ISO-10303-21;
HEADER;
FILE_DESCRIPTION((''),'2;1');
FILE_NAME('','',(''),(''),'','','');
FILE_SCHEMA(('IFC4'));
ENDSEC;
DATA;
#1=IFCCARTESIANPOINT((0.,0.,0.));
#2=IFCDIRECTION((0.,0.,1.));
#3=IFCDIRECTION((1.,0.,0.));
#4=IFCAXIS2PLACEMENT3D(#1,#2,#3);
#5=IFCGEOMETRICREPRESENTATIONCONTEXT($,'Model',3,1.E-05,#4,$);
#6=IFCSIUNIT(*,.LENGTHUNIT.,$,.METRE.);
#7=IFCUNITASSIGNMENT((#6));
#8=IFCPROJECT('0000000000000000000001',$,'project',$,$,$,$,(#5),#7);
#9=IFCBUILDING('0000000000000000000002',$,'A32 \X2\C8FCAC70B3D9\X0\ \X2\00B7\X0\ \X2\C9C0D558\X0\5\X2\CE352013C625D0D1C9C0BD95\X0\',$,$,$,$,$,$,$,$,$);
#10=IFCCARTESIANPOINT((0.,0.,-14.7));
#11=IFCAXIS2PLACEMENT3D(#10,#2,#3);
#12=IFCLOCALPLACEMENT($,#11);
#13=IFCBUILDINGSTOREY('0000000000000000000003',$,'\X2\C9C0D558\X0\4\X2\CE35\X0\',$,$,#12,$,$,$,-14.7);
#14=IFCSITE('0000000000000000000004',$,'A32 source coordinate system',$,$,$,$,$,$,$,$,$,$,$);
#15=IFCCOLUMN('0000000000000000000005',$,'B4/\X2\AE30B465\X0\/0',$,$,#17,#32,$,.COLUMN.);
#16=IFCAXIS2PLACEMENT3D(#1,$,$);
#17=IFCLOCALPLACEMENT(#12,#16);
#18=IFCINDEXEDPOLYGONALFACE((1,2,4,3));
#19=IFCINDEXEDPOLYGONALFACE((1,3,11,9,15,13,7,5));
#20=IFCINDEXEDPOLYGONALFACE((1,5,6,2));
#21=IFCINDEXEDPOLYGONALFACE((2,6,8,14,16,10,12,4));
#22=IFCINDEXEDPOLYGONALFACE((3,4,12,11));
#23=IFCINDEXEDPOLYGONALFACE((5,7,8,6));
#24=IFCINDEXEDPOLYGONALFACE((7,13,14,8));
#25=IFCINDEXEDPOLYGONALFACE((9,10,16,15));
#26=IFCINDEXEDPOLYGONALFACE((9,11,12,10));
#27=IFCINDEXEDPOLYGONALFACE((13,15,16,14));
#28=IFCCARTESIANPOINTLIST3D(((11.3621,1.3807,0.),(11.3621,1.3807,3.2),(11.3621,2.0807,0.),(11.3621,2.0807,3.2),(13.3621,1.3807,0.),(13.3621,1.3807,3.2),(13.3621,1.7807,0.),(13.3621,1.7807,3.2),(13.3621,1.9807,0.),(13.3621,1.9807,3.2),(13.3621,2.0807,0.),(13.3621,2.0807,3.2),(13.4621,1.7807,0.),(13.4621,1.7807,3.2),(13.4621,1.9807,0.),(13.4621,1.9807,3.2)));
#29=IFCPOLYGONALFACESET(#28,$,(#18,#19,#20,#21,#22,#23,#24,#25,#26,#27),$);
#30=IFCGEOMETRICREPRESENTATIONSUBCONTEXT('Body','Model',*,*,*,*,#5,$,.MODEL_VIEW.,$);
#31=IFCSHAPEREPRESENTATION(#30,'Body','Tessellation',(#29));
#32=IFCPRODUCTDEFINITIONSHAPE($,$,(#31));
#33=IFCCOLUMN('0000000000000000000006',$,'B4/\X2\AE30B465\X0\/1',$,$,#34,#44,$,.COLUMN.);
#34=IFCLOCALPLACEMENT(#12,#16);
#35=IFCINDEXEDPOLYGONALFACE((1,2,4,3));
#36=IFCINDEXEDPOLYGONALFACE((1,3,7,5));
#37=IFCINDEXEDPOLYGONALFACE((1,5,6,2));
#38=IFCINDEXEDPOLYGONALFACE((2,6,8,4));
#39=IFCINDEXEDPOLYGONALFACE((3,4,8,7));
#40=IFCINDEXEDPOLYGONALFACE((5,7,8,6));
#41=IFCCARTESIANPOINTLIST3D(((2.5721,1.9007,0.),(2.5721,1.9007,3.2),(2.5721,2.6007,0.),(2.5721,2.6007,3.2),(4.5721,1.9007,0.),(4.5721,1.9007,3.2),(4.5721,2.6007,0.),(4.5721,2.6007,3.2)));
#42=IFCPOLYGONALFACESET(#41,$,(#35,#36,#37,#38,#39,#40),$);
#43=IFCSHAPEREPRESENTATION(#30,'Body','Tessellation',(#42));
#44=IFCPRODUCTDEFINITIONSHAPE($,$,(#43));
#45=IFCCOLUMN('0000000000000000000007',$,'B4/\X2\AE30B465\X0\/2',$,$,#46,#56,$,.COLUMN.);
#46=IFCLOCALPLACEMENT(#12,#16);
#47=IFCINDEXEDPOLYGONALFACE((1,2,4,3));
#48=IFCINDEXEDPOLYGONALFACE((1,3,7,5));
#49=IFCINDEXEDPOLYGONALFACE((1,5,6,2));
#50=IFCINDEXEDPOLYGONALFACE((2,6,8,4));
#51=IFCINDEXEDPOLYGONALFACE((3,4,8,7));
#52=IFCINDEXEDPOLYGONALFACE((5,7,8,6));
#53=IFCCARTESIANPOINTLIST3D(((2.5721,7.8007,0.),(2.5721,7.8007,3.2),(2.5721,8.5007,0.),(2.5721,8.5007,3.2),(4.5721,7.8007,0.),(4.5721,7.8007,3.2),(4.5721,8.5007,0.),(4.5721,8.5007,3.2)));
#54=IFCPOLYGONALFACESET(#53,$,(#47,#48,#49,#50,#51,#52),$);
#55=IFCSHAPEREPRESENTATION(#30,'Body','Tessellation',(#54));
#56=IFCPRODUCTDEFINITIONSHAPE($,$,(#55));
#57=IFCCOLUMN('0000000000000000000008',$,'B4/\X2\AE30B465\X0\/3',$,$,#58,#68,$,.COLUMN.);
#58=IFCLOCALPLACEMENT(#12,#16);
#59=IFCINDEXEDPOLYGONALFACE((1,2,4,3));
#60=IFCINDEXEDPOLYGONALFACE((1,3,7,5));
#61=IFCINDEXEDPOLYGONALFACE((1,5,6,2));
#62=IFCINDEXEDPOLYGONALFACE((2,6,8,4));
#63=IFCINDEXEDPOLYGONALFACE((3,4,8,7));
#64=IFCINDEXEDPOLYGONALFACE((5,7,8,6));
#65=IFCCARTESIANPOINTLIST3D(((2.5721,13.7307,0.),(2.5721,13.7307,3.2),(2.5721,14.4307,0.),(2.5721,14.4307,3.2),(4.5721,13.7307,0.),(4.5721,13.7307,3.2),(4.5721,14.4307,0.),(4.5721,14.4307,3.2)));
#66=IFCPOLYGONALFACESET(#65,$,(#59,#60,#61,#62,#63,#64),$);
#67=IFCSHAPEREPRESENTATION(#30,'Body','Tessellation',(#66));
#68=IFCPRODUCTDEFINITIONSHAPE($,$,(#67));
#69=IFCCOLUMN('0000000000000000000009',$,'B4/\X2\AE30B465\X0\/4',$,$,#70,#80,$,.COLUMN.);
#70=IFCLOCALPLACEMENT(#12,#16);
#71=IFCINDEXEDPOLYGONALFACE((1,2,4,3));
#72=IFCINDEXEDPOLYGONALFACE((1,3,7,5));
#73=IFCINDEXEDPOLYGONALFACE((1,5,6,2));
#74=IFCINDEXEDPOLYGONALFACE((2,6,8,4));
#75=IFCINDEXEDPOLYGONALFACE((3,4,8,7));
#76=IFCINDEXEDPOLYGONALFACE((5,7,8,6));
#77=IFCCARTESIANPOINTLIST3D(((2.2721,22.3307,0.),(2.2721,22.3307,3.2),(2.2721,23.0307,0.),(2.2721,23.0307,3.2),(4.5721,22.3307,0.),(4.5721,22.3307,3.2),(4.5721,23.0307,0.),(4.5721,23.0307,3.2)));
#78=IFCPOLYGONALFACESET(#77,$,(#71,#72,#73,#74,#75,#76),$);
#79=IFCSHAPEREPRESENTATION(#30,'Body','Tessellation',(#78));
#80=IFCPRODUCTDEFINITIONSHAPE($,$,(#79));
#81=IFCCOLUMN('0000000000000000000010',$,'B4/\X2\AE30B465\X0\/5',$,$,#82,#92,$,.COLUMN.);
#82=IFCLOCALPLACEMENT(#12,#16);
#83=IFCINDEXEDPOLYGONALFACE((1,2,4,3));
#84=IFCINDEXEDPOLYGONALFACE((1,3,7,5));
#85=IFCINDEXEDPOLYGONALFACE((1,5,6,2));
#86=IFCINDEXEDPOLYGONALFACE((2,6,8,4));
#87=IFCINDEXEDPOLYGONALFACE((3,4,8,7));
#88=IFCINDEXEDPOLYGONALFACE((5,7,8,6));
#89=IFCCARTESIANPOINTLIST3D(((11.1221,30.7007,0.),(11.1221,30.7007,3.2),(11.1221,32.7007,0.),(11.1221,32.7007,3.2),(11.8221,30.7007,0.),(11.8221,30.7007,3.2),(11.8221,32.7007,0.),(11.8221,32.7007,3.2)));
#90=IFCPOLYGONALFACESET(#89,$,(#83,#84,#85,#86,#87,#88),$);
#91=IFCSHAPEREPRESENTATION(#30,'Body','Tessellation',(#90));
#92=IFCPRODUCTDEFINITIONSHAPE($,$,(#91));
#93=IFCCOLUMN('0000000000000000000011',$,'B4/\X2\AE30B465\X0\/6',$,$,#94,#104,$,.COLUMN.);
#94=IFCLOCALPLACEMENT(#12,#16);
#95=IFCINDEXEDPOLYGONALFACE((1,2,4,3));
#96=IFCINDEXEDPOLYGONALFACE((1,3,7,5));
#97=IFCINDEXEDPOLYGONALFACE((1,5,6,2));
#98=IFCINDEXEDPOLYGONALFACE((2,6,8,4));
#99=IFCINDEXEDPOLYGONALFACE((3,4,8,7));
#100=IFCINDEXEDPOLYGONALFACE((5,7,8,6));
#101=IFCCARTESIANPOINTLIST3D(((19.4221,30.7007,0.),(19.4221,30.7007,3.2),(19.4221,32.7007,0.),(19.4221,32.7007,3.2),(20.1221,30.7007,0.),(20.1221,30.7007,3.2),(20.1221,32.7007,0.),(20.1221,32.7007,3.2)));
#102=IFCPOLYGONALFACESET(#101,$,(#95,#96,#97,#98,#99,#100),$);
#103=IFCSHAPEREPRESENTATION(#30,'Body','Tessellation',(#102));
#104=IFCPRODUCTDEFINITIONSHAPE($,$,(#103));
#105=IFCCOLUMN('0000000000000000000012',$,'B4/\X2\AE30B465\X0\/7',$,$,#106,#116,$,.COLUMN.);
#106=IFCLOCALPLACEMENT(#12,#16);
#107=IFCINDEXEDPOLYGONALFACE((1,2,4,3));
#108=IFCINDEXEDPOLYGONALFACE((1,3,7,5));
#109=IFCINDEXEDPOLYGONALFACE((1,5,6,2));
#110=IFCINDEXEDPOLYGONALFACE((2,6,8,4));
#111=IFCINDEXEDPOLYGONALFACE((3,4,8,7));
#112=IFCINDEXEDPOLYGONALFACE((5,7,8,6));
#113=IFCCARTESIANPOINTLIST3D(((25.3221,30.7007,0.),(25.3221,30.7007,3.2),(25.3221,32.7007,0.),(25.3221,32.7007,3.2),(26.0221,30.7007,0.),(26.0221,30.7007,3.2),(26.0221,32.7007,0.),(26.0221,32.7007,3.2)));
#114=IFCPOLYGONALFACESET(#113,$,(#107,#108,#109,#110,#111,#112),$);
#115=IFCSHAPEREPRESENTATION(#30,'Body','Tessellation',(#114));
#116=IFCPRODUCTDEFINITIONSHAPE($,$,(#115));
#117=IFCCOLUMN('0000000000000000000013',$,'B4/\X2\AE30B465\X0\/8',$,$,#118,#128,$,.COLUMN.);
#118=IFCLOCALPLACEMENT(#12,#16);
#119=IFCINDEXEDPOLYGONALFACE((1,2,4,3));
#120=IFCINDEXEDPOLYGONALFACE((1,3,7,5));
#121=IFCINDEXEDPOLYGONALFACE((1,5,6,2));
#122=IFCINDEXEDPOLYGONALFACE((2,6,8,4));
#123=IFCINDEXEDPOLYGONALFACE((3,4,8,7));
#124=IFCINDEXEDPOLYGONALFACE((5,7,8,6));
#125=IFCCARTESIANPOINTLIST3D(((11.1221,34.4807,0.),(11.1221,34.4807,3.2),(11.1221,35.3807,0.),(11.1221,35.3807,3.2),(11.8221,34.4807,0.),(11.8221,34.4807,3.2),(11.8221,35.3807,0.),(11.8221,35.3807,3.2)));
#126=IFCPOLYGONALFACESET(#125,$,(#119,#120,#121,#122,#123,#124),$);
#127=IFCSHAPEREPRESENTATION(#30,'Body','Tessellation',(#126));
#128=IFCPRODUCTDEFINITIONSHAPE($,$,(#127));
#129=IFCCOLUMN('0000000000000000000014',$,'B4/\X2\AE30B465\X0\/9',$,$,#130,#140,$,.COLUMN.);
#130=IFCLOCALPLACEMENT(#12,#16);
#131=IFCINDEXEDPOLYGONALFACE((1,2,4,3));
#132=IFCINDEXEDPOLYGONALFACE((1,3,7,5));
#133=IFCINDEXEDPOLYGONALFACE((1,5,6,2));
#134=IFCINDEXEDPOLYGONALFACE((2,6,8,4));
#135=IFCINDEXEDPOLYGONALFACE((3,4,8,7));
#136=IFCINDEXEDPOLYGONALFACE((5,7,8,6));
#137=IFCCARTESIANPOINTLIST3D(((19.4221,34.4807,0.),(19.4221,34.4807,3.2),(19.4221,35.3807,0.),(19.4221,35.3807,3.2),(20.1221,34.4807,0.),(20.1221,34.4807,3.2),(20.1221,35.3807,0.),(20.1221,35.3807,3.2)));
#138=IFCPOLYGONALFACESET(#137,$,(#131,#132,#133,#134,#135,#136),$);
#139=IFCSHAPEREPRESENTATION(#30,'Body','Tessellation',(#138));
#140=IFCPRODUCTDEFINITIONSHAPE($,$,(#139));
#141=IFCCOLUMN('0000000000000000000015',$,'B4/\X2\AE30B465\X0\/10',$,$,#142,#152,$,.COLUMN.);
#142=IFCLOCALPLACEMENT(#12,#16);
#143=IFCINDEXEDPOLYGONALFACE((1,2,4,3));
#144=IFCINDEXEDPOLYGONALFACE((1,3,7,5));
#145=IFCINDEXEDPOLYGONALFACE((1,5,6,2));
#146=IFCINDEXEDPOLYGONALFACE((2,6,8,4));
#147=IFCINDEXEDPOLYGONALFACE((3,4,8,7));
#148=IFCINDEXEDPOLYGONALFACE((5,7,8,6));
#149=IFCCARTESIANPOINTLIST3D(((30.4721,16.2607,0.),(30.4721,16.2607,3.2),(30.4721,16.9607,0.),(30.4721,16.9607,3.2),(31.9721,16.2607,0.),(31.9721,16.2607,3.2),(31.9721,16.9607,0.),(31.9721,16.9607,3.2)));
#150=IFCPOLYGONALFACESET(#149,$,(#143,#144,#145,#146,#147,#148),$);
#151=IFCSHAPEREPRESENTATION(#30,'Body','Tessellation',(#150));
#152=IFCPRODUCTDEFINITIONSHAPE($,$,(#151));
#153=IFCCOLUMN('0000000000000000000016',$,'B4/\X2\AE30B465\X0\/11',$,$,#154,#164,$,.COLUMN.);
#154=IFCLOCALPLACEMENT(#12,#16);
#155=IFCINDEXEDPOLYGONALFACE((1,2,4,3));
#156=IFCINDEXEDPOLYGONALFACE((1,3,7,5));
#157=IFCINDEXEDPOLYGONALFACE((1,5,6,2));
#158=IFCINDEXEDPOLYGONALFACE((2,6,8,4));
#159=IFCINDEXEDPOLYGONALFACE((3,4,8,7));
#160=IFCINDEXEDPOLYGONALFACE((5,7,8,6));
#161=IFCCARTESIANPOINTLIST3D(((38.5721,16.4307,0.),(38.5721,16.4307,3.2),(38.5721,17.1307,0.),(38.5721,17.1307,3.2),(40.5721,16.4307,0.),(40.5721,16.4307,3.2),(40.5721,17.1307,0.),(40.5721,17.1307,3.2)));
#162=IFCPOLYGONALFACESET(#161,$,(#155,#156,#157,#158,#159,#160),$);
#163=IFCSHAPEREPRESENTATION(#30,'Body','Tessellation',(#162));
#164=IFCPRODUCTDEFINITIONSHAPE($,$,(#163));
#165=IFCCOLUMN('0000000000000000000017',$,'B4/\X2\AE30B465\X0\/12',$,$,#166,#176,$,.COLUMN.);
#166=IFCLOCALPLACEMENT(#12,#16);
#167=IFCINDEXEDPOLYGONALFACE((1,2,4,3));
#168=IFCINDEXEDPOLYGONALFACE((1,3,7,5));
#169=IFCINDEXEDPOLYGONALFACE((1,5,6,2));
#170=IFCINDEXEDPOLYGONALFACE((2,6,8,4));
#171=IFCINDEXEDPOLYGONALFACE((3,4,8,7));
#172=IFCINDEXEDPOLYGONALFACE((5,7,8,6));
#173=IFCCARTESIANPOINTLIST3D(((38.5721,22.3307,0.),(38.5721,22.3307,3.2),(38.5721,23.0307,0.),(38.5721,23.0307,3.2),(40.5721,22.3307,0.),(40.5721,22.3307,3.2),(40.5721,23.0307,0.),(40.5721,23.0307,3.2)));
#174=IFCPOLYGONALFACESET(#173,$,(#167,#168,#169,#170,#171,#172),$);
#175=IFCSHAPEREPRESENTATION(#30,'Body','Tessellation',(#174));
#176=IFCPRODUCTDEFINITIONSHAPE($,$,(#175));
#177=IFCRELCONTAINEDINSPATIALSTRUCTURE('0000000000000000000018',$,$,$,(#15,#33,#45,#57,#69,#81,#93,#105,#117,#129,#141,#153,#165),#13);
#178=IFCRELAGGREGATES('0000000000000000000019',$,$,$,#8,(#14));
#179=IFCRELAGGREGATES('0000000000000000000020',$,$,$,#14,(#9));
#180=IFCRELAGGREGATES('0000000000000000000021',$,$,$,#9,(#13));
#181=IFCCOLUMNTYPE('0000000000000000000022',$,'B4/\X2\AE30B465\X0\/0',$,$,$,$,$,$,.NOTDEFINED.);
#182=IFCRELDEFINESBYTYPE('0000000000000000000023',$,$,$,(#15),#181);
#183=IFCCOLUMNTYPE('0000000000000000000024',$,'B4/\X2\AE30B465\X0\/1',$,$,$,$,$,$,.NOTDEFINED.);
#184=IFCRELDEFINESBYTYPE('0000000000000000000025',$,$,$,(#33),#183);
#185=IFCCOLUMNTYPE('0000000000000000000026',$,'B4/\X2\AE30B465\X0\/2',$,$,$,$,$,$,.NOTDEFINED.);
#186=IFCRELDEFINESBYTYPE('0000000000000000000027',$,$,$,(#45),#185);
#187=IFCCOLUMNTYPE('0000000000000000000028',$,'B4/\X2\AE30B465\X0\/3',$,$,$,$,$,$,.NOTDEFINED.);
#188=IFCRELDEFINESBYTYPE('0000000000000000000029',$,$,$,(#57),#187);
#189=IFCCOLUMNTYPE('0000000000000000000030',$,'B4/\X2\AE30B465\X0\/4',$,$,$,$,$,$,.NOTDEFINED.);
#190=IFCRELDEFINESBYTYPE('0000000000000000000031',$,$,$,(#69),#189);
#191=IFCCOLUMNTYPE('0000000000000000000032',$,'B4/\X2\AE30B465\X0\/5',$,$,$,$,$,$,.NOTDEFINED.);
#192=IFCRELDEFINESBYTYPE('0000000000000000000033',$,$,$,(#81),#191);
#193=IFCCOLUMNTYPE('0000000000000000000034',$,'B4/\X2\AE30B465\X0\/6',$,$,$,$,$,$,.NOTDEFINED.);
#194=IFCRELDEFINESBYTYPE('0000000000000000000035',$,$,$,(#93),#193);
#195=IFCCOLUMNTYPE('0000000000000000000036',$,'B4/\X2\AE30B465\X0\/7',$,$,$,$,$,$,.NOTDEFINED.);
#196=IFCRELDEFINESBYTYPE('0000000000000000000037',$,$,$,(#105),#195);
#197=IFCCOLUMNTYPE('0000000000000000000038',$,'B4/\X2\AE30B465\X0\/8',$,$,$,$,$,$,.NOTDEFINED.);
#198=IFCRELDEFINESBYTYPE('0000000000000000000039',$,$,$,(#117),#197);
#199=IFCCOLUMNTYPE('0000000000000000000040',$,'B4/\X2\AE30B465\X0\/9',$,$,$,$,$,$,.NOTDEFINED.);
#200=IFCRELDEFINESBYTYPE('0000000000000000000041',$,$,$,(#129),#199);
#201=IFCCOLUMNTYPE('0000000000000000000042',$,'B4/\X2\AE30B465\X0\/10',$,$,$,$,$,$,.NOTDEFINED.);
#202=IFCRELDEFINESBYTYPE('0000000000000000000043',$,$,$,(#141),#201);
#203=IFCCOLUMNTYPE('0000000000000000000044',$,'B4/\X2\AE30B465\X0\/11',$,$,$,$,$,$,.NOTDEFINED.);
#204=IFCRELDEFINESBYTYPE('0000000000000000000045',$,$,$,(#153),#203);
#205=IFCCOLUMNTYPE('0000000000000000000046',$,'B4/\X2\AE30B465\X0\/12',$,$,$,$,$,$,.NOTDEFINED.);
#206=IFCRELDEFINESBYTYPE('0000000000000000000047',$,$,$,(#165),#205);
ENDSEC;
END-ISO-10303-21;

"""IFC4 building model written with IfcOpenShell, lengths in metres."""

from ifc_helpers import new_model, si_unit, frame, origin, origin_with_axes, place, context, subcontext, project, spatial, polyline, outline, extrude, source, transform, mapped, type_object, type_shapes, element, save


model = new_model("IFC4")

# Units and contexts
model_context = context("Model", 3, precision=1e-05, world=origin_with_axes())
body_context = subcontext(model_context, "Body", "Model", "MODEL_VIEW")
ifc_project = project(units=[si_unit("LENGTHUNIT", "METRE")], contexts=[model_context])

# Site, building, storey
site = spatial("IfcSite", under=ifc_project, Name="A32 source coordinate system")
building = spatial("IfcBuilding", under=site, Name="A32 주거동 · 지하5층–옥탑지붕")
storey_placement = place(None, frame((0.0, 0.0, -14.7), z_axis=(0.0, 0.0, 1.0), x_axis=(1.0, 0.0, 0.0)))
storey = spatial("IfcBuildingStorey", under=building, at=storey_placement, Name="지하4층", Elevation=-14.7)

# Columns
column_type_1 = type_object("IfcColumnType", Name="B4/기둥/0", PredefinedType="NOTDEFINED")
shared_shape_1 = source(origin(), body_context, "Body", "SweptSolid", [
    extrude(outline(polyline([(11.3621, 1.3807), (11.3621, 2.0807), (13.3621, 2.0807), (13.3621, 1.9807), (13.4621, 1.9807), (13.4621, 1.7807), (13.3621, 1.7807), (13.3621, 1.3807), (11.3621, 1.3807)])), origin(), (0.0, 0.0, 1.0), 3.2),
])
type_shapes(column_type_1, [shared_shape_1])
column_1_placement = place(storey_placement, origin_with_axes())
element("IfcColumn", 1, at=column_1_placement, inside=storey, type_object=column_type_1, Name="B4/기둥/0", PredefinedType="COLUMN", context=body_context, shape_type="MappedRepresentation", body=[
    mapped(shared_shape_1, transform((0.0, 0.0, 0.0), scale=1.0)),
])
column_type_2 = type_object("IfcColumnType", Name="B4/기둥/1", PredefinedType="NOTDEFINED")
shared_shape_2 = source(origin(), body_context, "Body", "SweptSolid", [
    extrude(outline(polyline([(4.5721, 1.9007), (2.5721, 1.9007), (2.5721, 2.6007), (4.5721, 2.6007), (4.5721, 1.9007)])), origin(), (0.0, 0.0, 1.0), 3.2),
])
type_shapes(column_type_2, [shared_shape_2])
column_2_placement = place(storey_placement, origin_with_axes())
element("IfcColumn", 2, at=column_2_placement, inside=storey, type_object=column_type_2, Name="B4/기둥/1", PredefinedType="COLUMN", context=body_context, shape_type="MappedRepresentation", body=[
    mapped(shared_shape_2, transform((0.0, 0.0, 0.0), scale=1.0)),
])
column_type_3 = type_object("IfcColumnType", Name="B4/기둥/2", PredefinedType="NOTDEFINED")
shared_shape_3 = source(origin(), body_context, "Body", "SweptSolid", [
    extrude(outline(polyline([(4.5721, 7.8007), (2.5721, 7.8007), (2.5721, 8.5007), (4.5721, 8.5007), (4.5721, 7.8007)])), origin(), (0.0, 0.0, 1.0), 3.2),
])
type_shapes(column_type_3, [shared_shape_3])
column_3_placement = place(storey_placement, origin_with_axes())
element("IfcColumn", 3, at=column_3_placement, inside=storey, type_object=column_type_3, Name="B4/기둥/2", PredefinedType="COLUMN", context=body_context, shape_type="MappedRepresentation", body=[
    mapped(shared_shape_3, transform((0.0, 0.0, 0.0), scale=1.0)),
])
column_type_4 = type_object("IfcColumnType", Name="B4/기둥/3", PredefinedType="NOTDEFINED")
shared_shape_4 = source(origin(), body_context, "Body", "SweptSolid", [
    extrude(outline(polyline([(4.5721, 14.4307), (4.5721, 13.7307), (2.5721, 13.7307), (2.5721, 14.4307), (4.5721, 14.4307)])), origin(), (0.0, 0.0, 1.0), 3.2),
])
type_shapes(column_type_4, [shared_shape_4])
column_4_placement = place(storey_placement, origin_with_axes())
element("IfcColumn", 4, at=column_4_placement, inside=storey, type_object=column_type_4, Name="B4/기둥/3", PredefinedType="COLUMN", context=body_context, shape_type="MappedRepresentation", body=[
    mapped(shared_shape_4, transform((0.0, 0.0, 0.0), scale=1.0)),
])
column_type_5 = type_object("IfcColumnType", Name="B4/기둥/4", PredefinedType="NOTDEFINED")
shared_shape_5 = source(origin(), body_context, "Body", "SweptSolid", [
    extrude(outline(polyline([(2.2721, 23.0307), (4.5721, 23.0307), (4.5721, 22.3307), (2.2721, 22.3307), (2.2721, 23.0307)])), origin(), (0.0, 0.0, 1.0), 3.2),
])
type_shapes(column_type_5, [shared_shape_5])
column_5_placement = place(storey_placement, origin_with_axes())
element("IfcColumn", 5, at=column_5_placement, inside=storey, type_object=column_type_5, Name="B4/기둥/4", PredefinedType="COLUMN", context=body_context, shape_type="MappedRepresentation", body=[
    mapped(shared_shape_5, transform((0.0, 0.0, 0.0), scale=1.0)),
])
column_type_6 = type_object("IfcColumnType", Name="B4/기둥/5", PredefinedType="NOTDEFINED")
shared_shape_6 = source(origin(), body_context, "Body", "SweptSolid", [
    extrude(outline(polyline([(11.8221, 30.7007), (11.1221, 30.7007), (11.1221, 32.7007), (11.8221, 32.7007), (11.8221, 30.7007)])), origin(), (0.0, 0.0, 1.0), 3.2),
])
type_shapes(column_type_6, [shared_shape_6])
column_6_placement = place(storey_placement, origin_with_axes())
element("IfcColumn", 6, at=column_6_placement, inside=storey, type_object=column_type_6, Name="B4/기둥/5", PredefinedType="COLUMN", context=body_context, shape_type="MappedRepresentation", body=[
    mapped(shared_shape_6, transform((0.0, 0.0, 0.0), scale=1.0)),
])
column_type_7 = type_object("IfcColumnType", Name="B4/기둥/6", PredefinedType="NOTDEFINED")
shared_shape_7 = source(origin(), body_context, "Body", "SweptSolid", [
    extrude(outline(polyline([(20.1221, 30.7007), (19.4221, 30.7007), (19.4221, 32.7007), (20.1221, 32.7007), (20.1221, 30.7007)])), origin(), (0.0, 0.0, 1.0), 3.2),
])
type_shapes(column_type_7, [shared_shape_7])
column_7_placement = place(storey_placement, origin_with_axes())
element("IfcColumn", 7, at=column_7_placement, inside=storey, type_object=column_type_7, Name="B4/기둥/6", PredefinedType="COLUMN", context=body_context, shape_type="MappedRepresentation", body=[
    mapped(shared_shape_7, transform((0.0, 0.0, 0.0), scale=1.0)),
])
column_type_8 = type_object("IfcColumnType", Name="B4/기둥/7", PredefinedType="NOTDEFINED")
shared_shape_8 = source(origin(), body_context, "Body", "SweptSolid", [
    extrude(outline(polyline([(26.0221, 30.7007), (25.3221, 30.7007), (25.3221, 32.7007), (26.0221, 32.7007), (26.0221, 30.7007)])), origin(), (0.0, 0.0, 1.0), 3.2),
])
type_shapes(column_type_8, [shared_shape_8])
column_8_placement = place(storey_placement, origin_with_axes())
element("IfcColumn", 8, at=column_8_placement, inside=storey, type_object=column_type_8, Name="B4/기둥/7", PredefinedType="COLUMN", context=body_context, shape_type="MappedRepresentation", body=[
    mapped(shared_shape_8, transform((0.0, 0.0, 0.0), scale=1.0)),
])
column_type_9 = type_object("IfcColumnType", Name="B4/기둥/8", PredefinedType="NOTDEFINED")
shared_shape_9 = source(origin(), body_context, "Body", "SweptSolid", [
    extrude(outline(polyline([(11.1221, 34.4807), (11.1221, 35.3807), (11.8221, 35.3807), (11.8221, 34.4807), (11.1221, 34.4807)])), origin(), (0.0, 0.0, 1.0), 3.2),
])
type_shapes(column_type_9, [shared_shape_9])
column_9_placement = place(storey_placement, origin_with_axes())
element("IfcColumn", 9, at=column_9_placement, inside=storey, type_object=column_type_9, Name="B4/기둥/8", PredefinedType="COLUMN", context=body_context, shape_type="MappedRepresentation", body=[
    mapped(shared_shape_9, transform((0.0, 0.0, 0.0), scale=1.0)),
])
column_type_10 = type_object("IfcColumnType", Name="B4/기둥/9", PredefinedType="NOTDEFINED")
shared_shape_10 = source(origin(), body_context, "Body", "SweptSolid", [
    extrude(outline(polyline([(20.1221, 35.3807), (20.1221, 34.4807), (19.4221, 34.4807), (19.4221, 35.3807), (20.1221, 35.3807)])), origin(), (0.0, 0.0, 1.0), 3.2),
])
type_shapes(column_type_10, [shared_shape_10])
column_10_placement = place(storey_placement, origin_with_axes())
element("IfcColumn", 10, at=column_10_placement, inside=storey, type_object=column_type_10, Name="B4/기둥/9", PredefinedType="COLUMN", context=body_context, shape_type="MappedRepresentation", body=[
    mapped(shared_shape_10, transform((0.0, 0.0, 0.0), scale=1.0)),
])
column_type_11 = type_object("IfcColumnType", Name="B4/기둥/10", PredefinedType="NOTDEFINED")
shared_shape_11 = source(origin(), body_context, "Body", "SweptSolid", [
    extrude(outline(polyline([(30.4721, 16.9607), (31.9721, 16.9607), (31.9721, 16.2607), (30.4721, 16.2607), (30.4721, 16.9607)])), origin(), (0.0, 0.0, 1.0), 3.2),
])
type_shapes(column_type_11, [shared_shape_11])
column_11_placement = place(storey_placement, origin_with_axes())
element("IfcColumn", 11, at=column_11_placement, inside=storey, type_object=column_type_11, Name="B4/기둥/10", PredefinedType="COLUMN", context=body_context, shape_type="MappedRepresentation", body=[
    mapped(shared_shape_11, transform((0.0, 0.0, 0.0), scale=1.0)),
])
column_type_12 = type_object("IfcColumnType", Name="B4/기둥/11", PredefinedType="NOTDEFINED")
shared_shape_12 = source(origin(), body_context, "Body", "SweptSolid", [
    extrude(outline(polyline([(40.5721, 16.4307), (38.5721, 16.4307), (38.5721, 17.1307), (40.5721, 17.1307), (40.5721, 16.4307)])), origin(), (0.0, 0.0, 1.0), 3.2),
])
type_shapes(column_type_12, [shared_shape_12])
column_12_placement = place(storey_placement, origin_with_axes())
element("IfcColumn", 12, at=column_12_placement, inside=storey, type_object=column_type_12, Name="B4/기둥/11", PredefinedType="COLUMN", context=body_context, shape_type="MappedRepresentation", body=[
    mapped(shared_shape_12, transform((0.0, 0.0, 0.0), scale=1.0)),
])
column_type_13 = type_object("IfcColumnType", Name="B4/기둥/12", PredefinedType="NOTDEFINED")
shared_shape_13 = source(origin(), body_context, "Body", "SweptSolid", [
    extrude(outline(polyline([(40.5721, 22.3307), (38.5721, 22.3307), (38.5721, 23.0307), (40.5721, 23.0307), (40.5721, 22.3307)])), origin(), (0.0, 0.0, 1.0), 3.2),
])
type_shapes(column_type_13, [shared_shape_13])
column_13_placement = place(storey_placement, origin_with_axes())
element("IfcColumn", 13, at=column_13_placement, inside=storey, type_object=column_type_13, Name="B4/기둥/12", PredefinedType="COLUMN", context=body_context, shape_type="MappedRepresentation", body=[
    mapped(shared_shape_13, transform((0.0, 0.0, 0.0), scale=1.0)),
])

save(model, "model.ifc")
